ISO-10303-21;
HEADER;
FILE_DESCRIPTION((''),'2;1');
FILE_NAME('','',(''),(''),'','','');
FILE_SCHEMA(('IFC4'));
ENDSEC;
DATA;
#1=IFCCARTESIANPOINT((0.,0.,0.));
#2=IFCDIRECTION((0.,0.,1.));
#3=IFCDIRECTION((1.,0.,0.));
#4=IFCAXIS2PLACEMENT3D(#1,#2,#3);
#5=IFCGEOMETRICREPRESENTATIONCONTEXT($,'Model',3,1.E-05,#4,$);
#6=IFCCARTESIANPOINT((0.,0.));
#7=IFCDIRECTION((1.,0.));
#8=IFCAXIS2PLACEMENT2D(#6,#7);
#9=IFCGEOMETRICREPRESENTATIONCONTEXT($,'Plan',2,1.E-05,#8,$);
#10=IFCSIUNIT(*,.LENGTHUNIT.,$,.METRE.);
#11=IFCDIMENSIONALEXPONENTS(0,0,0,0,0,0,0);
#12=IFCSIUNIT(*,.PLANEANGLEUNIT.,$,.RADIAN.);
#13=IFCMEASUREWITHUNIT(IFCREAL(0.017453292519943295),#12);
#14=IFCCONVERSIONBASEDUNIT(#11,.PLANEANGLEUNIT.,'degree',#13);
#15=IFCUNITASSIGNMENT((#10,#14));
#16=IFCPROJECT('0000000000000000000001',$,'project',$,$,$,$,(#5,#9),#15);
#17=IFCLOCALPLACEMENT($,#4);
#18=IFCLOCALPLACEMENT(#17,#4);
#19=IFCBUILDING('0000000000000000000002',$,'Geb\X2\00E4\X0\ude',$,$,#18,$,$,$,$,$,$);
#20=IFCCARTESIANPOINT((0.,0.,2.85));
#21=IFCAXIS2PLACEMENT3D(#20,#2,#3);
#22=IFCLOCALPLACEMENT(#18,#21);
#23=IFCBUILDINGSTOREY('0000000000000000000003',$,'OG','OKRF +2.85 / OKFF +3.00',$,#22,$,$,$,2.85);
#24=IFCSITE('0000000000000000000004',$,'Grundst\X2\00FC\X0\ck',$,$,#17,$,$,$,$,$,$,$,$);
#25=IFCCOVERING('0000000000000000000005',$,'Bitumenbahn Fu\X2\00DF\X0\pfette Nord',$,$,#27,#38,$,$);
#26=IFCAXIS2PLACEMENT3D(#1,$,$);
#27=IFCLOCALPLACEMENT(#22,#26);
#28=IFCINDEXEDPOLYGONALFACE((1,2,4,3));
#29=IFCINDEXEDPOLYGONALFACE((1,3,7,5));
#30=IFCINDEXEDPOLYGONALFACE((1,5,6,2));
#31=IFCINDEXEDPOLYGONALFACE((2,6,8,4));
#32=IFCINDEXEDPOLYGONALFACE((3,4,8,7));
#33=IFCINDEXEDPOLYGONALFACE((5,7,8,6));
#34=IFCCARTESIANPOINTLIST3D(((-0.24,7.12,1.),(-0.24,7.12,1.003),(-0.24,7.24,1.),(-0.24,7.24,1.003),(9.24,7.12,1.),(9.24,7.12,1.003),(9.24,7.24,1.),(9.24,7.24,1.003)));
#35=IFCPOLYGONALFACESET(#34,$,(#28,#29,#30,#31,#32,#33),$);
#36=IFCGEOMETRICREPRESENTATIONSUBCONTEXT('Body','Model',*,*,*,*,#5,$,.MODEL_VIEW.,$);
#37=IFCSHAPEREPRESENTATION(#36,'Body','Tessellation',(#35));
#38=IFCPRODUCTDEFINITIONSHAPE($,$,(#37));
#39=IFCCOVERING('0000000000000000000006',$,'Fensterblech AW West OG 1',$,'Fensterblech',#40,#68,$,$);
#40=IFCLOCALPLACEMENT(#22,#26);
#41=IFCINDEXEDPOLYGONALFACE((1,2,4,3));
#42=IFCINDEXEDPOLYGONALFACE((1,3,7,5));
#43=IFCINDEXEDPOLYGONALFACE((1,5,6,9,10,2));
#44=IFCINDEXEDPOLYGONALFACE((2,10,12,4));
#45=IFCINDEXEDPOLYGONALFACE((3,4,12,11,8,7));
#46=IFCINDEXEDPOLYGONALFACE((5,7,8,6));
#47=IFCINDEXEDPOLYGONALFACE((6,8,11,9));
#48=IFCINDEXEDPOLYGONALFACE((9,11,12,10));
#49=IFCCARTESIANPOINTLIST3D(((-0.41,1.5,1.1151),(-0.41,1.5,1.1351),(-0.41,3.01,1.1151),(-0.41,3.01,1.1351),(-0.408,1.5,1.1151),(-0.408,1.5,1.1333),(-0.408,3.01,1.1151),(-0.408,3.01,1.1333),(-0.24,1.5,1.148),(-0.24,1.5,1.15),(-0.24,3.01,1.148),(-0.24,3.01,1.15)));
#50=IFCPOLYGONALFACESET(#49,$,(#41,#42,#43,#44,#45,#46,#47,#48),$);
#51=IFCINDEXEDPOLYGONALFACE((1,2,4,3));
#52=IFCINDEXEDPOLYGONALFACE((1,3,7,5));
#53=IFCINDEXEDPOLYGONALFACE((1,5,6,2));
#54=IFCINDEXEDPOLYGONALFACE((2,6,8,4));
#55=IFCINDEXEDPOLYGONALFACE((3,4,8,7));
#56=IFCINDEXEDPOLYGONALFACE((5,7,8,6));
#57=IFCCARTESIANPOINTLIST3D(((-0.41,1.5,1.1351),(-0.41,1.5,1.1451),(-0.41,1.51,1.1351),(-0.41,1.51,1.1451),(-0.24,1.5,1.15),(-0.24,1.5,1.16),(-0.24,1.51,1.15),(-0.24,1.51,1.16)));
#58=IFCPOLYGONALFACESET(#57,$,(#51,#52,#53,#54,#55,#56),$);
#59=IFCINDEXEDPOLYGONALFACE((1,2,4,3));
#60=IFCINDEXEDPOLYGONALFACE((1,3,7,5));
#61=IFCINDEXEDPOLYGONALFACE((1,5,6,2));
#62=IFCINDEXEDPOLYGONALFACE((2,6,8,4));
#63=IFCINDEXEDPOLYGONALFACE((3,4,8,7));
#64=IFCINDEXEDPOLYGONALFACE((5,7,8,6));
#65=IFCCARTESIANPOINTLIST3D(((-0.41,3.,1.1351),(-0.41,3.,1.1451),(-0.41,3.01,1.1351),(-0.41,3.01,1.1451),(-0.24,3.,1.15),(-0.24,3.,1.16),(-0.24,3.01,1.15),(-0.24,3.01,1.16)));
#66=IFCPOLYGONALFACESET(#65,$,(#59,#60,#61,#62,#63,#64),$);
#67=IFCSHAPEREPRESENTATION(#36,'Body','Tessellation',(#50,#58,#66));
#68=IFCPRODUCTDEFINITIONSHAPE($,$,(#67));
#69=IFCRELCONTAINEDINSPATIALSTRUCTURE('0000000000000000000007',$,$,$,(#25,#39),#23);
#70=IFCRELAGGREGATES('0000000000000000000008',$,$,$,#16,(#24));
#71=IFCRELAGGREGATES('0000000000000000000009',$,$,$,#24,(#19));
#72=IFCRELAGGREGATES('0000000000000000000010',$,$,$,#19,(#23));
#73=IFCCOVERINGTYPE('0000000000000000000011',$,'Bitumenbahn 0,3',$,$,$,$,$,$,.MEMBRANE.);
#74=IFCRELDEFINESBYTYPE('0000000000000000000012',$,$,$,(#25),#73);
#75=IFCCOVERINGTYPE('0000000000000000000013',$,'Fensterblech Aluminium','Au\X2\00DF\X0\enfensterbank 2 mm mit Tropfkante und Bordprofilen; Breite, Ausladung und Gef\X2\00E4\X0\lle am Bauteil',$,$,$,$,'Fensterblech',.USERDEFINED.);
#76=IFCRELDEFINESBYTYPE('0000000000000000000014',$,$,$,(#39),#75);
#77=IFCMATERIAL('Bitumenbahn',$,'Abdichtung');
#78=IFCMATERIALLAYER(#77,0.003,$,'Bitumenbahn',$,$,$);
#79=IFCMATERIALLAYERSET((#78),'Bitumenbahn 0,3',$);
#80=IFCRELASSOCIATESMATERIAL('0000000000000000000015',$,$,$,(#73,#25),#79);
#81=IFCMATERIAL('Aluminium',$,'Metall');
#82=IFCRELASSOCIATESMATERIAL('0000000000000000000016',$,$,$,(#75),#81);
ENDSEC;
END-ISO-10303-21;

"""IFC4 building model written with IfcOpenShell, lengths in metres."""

from ifc_helpers import new_model, entity, si_unit, converted_unit, frame, origin_with_axes, origin_2d_with_axis, place, context, subcontext, project, spatial, polyline, indexed_curve, outline, extrude, material, layer, layer_set, layer_usage, type_object, element, save


model = new_model("IFC4")

# Units and contexts
model_context = context("Model", 3, precision=1e-05, world=origin_with_axes())
plan_context = context("Plan", 2, precision=1e-05, world=origin_2d_with_axis())
body_context_1 = subcontext(model_context, "Body", "Model", "MODEL_VIEW")
ifc_project = project(units=[si_unit("LENGTHUNIT", "METRE"), converted_unit("PLANEANGLEUNIT", "degree", entity("IfcReal", 0.017453292519943295), si_unit("PLANEANGLEUNIT", "RADIAN"), dimensions=[0, 0, 0, 0, 0, 0, 0])], contexts=[model_context, plan_context])

# Site, building, storey
site_placement = place(None, origin_with_axes())
site = spatial("IfcSite", under=ifc_project, at=site_placement, Name="Grundstück")
building_placement = place(site_placement, origin_with_axes())
building = spatial("IfcBuilding", under=site, at=building_placement, Name="Gebäude")
storey_placement = place(building_placement, frame((0.0, 0.0, 2.85), z_axis=(0.0, 0.0, 1.0), x_axis=(1.0, 0.0, 0.0)))
storey = spatial("IfcBuildingStorey", under=building, at=storey_placement, Name="OG", Description="OKRF +2.85 / OKFF +3.00", Elevation=2.85)

# Coverings
ifc_material_1 = material(Name="Bitumenbahn", Category="Abdichtung")
ifc_layer_1 = layer(ifc_material_1, 0.003, Name="Bitumenbahn")
ifc_layer_set_1 = layer_set([ifc_layer_1], Name="Bitumenbahn 0,3")
covering_type_1 = type_object("IfcCoveringType", Name="Bitumenbahn 0,3", PredefinedType="MEMBRANE", material=ifc_layer_set_1)
ifc_layer_usage_1 = layer_usage(ifc_layer_set_1, "AXIS3", "POSITIVE", 0.0)
covering_1_placement = place(storey_placement, frame((0.0, 0.0, 1.0), z_axis=(0.0, 0.0, 1.0), x_axis=(1.0, 0.0, 0.0)))
element("IfcCovering", 1, at=covering_1_placement, inside=storey, type_object=covering_type_1, material=ifc_layer_usage_1, Name="Bitumenbahn Fußpfette Nord", context=body_context_1, shape_type="SweptSolid", body=[
    extrude(outline(indexed_curve([(-0.24, 7.12), (9.24, 7.12), (9.24, 7.24), (-0.24, 7.24)])), None, (0.0, 0.0, 1.0), 0.003),
])
ifc_material_2 = material(Name="Aluminium", Category="Metall")
covering_type_2 = type_object("IfcCoveringType", Name="Fensterblech Aluminium", Description="Außenfensterbank 2 mm mit Tropfkante und Bordprofilen; Breite, Ausladung und Gefälle am Bauteil", ElementType="Fensterblech", PredefinedType="USERDEFINED", material=ifc_material_2)
covering_2_placement = place(storey_placement, frame((0.0, 0.0, 0.0), z_axis=(0.0, 0.0, 1.0), x_axis=(0.0, 1.0, 0.0)))
element("IfcCovering", 2, at=covering_2_placement, inside=storey, type_object=covering_type_2, Name="Fensterblech AW West OG 1", ObjectType="Fensterblech", context=body_context_1, shape_type="SweptSolid", body=[
    extrude(outline(polyline([(0.24, 1.148), (0.408, 1.1333), (0.408, 1.1151), (0.41, 1.1151), (0.41, 1.1351), (0.24, 1.15), (0.24, 1.148)])), frame((1.5, 0.0, 0.0), z_axis=(1.0, 0.0, 0.0), x_axis=(0.0, 1.0, 0.0)), (0.0, 0.0, 1.0), 1.51),
    extrude(outline(polyline([(0.24, 1.15), (0.41, 1.1351), (0.41, 1.1451), (0.24, 1.16), (0.24, 1.15)])), frame((1.5, 0.0, 0.0), z_axis=(1.0, 0.0, 0.0), x_axis=(0.0, 1.0, 0.0)), (0.0, 0.0, 1.0), 0.01),
    extrude(outline(polyline([(0.24, 1.15), (0.41, 1.1351), (0.41, 1.1451), (0.24, 1.16), (0.24, 1.15)])), frame((3.0, 0.0, 0.0), z_axis=(1.0, 0.0, 0.0), x_axis=(0.0, 1.0, 0.0)), (0.0, 0.0, 1.0), 0.01),
])

save(model, "model.ifc")
